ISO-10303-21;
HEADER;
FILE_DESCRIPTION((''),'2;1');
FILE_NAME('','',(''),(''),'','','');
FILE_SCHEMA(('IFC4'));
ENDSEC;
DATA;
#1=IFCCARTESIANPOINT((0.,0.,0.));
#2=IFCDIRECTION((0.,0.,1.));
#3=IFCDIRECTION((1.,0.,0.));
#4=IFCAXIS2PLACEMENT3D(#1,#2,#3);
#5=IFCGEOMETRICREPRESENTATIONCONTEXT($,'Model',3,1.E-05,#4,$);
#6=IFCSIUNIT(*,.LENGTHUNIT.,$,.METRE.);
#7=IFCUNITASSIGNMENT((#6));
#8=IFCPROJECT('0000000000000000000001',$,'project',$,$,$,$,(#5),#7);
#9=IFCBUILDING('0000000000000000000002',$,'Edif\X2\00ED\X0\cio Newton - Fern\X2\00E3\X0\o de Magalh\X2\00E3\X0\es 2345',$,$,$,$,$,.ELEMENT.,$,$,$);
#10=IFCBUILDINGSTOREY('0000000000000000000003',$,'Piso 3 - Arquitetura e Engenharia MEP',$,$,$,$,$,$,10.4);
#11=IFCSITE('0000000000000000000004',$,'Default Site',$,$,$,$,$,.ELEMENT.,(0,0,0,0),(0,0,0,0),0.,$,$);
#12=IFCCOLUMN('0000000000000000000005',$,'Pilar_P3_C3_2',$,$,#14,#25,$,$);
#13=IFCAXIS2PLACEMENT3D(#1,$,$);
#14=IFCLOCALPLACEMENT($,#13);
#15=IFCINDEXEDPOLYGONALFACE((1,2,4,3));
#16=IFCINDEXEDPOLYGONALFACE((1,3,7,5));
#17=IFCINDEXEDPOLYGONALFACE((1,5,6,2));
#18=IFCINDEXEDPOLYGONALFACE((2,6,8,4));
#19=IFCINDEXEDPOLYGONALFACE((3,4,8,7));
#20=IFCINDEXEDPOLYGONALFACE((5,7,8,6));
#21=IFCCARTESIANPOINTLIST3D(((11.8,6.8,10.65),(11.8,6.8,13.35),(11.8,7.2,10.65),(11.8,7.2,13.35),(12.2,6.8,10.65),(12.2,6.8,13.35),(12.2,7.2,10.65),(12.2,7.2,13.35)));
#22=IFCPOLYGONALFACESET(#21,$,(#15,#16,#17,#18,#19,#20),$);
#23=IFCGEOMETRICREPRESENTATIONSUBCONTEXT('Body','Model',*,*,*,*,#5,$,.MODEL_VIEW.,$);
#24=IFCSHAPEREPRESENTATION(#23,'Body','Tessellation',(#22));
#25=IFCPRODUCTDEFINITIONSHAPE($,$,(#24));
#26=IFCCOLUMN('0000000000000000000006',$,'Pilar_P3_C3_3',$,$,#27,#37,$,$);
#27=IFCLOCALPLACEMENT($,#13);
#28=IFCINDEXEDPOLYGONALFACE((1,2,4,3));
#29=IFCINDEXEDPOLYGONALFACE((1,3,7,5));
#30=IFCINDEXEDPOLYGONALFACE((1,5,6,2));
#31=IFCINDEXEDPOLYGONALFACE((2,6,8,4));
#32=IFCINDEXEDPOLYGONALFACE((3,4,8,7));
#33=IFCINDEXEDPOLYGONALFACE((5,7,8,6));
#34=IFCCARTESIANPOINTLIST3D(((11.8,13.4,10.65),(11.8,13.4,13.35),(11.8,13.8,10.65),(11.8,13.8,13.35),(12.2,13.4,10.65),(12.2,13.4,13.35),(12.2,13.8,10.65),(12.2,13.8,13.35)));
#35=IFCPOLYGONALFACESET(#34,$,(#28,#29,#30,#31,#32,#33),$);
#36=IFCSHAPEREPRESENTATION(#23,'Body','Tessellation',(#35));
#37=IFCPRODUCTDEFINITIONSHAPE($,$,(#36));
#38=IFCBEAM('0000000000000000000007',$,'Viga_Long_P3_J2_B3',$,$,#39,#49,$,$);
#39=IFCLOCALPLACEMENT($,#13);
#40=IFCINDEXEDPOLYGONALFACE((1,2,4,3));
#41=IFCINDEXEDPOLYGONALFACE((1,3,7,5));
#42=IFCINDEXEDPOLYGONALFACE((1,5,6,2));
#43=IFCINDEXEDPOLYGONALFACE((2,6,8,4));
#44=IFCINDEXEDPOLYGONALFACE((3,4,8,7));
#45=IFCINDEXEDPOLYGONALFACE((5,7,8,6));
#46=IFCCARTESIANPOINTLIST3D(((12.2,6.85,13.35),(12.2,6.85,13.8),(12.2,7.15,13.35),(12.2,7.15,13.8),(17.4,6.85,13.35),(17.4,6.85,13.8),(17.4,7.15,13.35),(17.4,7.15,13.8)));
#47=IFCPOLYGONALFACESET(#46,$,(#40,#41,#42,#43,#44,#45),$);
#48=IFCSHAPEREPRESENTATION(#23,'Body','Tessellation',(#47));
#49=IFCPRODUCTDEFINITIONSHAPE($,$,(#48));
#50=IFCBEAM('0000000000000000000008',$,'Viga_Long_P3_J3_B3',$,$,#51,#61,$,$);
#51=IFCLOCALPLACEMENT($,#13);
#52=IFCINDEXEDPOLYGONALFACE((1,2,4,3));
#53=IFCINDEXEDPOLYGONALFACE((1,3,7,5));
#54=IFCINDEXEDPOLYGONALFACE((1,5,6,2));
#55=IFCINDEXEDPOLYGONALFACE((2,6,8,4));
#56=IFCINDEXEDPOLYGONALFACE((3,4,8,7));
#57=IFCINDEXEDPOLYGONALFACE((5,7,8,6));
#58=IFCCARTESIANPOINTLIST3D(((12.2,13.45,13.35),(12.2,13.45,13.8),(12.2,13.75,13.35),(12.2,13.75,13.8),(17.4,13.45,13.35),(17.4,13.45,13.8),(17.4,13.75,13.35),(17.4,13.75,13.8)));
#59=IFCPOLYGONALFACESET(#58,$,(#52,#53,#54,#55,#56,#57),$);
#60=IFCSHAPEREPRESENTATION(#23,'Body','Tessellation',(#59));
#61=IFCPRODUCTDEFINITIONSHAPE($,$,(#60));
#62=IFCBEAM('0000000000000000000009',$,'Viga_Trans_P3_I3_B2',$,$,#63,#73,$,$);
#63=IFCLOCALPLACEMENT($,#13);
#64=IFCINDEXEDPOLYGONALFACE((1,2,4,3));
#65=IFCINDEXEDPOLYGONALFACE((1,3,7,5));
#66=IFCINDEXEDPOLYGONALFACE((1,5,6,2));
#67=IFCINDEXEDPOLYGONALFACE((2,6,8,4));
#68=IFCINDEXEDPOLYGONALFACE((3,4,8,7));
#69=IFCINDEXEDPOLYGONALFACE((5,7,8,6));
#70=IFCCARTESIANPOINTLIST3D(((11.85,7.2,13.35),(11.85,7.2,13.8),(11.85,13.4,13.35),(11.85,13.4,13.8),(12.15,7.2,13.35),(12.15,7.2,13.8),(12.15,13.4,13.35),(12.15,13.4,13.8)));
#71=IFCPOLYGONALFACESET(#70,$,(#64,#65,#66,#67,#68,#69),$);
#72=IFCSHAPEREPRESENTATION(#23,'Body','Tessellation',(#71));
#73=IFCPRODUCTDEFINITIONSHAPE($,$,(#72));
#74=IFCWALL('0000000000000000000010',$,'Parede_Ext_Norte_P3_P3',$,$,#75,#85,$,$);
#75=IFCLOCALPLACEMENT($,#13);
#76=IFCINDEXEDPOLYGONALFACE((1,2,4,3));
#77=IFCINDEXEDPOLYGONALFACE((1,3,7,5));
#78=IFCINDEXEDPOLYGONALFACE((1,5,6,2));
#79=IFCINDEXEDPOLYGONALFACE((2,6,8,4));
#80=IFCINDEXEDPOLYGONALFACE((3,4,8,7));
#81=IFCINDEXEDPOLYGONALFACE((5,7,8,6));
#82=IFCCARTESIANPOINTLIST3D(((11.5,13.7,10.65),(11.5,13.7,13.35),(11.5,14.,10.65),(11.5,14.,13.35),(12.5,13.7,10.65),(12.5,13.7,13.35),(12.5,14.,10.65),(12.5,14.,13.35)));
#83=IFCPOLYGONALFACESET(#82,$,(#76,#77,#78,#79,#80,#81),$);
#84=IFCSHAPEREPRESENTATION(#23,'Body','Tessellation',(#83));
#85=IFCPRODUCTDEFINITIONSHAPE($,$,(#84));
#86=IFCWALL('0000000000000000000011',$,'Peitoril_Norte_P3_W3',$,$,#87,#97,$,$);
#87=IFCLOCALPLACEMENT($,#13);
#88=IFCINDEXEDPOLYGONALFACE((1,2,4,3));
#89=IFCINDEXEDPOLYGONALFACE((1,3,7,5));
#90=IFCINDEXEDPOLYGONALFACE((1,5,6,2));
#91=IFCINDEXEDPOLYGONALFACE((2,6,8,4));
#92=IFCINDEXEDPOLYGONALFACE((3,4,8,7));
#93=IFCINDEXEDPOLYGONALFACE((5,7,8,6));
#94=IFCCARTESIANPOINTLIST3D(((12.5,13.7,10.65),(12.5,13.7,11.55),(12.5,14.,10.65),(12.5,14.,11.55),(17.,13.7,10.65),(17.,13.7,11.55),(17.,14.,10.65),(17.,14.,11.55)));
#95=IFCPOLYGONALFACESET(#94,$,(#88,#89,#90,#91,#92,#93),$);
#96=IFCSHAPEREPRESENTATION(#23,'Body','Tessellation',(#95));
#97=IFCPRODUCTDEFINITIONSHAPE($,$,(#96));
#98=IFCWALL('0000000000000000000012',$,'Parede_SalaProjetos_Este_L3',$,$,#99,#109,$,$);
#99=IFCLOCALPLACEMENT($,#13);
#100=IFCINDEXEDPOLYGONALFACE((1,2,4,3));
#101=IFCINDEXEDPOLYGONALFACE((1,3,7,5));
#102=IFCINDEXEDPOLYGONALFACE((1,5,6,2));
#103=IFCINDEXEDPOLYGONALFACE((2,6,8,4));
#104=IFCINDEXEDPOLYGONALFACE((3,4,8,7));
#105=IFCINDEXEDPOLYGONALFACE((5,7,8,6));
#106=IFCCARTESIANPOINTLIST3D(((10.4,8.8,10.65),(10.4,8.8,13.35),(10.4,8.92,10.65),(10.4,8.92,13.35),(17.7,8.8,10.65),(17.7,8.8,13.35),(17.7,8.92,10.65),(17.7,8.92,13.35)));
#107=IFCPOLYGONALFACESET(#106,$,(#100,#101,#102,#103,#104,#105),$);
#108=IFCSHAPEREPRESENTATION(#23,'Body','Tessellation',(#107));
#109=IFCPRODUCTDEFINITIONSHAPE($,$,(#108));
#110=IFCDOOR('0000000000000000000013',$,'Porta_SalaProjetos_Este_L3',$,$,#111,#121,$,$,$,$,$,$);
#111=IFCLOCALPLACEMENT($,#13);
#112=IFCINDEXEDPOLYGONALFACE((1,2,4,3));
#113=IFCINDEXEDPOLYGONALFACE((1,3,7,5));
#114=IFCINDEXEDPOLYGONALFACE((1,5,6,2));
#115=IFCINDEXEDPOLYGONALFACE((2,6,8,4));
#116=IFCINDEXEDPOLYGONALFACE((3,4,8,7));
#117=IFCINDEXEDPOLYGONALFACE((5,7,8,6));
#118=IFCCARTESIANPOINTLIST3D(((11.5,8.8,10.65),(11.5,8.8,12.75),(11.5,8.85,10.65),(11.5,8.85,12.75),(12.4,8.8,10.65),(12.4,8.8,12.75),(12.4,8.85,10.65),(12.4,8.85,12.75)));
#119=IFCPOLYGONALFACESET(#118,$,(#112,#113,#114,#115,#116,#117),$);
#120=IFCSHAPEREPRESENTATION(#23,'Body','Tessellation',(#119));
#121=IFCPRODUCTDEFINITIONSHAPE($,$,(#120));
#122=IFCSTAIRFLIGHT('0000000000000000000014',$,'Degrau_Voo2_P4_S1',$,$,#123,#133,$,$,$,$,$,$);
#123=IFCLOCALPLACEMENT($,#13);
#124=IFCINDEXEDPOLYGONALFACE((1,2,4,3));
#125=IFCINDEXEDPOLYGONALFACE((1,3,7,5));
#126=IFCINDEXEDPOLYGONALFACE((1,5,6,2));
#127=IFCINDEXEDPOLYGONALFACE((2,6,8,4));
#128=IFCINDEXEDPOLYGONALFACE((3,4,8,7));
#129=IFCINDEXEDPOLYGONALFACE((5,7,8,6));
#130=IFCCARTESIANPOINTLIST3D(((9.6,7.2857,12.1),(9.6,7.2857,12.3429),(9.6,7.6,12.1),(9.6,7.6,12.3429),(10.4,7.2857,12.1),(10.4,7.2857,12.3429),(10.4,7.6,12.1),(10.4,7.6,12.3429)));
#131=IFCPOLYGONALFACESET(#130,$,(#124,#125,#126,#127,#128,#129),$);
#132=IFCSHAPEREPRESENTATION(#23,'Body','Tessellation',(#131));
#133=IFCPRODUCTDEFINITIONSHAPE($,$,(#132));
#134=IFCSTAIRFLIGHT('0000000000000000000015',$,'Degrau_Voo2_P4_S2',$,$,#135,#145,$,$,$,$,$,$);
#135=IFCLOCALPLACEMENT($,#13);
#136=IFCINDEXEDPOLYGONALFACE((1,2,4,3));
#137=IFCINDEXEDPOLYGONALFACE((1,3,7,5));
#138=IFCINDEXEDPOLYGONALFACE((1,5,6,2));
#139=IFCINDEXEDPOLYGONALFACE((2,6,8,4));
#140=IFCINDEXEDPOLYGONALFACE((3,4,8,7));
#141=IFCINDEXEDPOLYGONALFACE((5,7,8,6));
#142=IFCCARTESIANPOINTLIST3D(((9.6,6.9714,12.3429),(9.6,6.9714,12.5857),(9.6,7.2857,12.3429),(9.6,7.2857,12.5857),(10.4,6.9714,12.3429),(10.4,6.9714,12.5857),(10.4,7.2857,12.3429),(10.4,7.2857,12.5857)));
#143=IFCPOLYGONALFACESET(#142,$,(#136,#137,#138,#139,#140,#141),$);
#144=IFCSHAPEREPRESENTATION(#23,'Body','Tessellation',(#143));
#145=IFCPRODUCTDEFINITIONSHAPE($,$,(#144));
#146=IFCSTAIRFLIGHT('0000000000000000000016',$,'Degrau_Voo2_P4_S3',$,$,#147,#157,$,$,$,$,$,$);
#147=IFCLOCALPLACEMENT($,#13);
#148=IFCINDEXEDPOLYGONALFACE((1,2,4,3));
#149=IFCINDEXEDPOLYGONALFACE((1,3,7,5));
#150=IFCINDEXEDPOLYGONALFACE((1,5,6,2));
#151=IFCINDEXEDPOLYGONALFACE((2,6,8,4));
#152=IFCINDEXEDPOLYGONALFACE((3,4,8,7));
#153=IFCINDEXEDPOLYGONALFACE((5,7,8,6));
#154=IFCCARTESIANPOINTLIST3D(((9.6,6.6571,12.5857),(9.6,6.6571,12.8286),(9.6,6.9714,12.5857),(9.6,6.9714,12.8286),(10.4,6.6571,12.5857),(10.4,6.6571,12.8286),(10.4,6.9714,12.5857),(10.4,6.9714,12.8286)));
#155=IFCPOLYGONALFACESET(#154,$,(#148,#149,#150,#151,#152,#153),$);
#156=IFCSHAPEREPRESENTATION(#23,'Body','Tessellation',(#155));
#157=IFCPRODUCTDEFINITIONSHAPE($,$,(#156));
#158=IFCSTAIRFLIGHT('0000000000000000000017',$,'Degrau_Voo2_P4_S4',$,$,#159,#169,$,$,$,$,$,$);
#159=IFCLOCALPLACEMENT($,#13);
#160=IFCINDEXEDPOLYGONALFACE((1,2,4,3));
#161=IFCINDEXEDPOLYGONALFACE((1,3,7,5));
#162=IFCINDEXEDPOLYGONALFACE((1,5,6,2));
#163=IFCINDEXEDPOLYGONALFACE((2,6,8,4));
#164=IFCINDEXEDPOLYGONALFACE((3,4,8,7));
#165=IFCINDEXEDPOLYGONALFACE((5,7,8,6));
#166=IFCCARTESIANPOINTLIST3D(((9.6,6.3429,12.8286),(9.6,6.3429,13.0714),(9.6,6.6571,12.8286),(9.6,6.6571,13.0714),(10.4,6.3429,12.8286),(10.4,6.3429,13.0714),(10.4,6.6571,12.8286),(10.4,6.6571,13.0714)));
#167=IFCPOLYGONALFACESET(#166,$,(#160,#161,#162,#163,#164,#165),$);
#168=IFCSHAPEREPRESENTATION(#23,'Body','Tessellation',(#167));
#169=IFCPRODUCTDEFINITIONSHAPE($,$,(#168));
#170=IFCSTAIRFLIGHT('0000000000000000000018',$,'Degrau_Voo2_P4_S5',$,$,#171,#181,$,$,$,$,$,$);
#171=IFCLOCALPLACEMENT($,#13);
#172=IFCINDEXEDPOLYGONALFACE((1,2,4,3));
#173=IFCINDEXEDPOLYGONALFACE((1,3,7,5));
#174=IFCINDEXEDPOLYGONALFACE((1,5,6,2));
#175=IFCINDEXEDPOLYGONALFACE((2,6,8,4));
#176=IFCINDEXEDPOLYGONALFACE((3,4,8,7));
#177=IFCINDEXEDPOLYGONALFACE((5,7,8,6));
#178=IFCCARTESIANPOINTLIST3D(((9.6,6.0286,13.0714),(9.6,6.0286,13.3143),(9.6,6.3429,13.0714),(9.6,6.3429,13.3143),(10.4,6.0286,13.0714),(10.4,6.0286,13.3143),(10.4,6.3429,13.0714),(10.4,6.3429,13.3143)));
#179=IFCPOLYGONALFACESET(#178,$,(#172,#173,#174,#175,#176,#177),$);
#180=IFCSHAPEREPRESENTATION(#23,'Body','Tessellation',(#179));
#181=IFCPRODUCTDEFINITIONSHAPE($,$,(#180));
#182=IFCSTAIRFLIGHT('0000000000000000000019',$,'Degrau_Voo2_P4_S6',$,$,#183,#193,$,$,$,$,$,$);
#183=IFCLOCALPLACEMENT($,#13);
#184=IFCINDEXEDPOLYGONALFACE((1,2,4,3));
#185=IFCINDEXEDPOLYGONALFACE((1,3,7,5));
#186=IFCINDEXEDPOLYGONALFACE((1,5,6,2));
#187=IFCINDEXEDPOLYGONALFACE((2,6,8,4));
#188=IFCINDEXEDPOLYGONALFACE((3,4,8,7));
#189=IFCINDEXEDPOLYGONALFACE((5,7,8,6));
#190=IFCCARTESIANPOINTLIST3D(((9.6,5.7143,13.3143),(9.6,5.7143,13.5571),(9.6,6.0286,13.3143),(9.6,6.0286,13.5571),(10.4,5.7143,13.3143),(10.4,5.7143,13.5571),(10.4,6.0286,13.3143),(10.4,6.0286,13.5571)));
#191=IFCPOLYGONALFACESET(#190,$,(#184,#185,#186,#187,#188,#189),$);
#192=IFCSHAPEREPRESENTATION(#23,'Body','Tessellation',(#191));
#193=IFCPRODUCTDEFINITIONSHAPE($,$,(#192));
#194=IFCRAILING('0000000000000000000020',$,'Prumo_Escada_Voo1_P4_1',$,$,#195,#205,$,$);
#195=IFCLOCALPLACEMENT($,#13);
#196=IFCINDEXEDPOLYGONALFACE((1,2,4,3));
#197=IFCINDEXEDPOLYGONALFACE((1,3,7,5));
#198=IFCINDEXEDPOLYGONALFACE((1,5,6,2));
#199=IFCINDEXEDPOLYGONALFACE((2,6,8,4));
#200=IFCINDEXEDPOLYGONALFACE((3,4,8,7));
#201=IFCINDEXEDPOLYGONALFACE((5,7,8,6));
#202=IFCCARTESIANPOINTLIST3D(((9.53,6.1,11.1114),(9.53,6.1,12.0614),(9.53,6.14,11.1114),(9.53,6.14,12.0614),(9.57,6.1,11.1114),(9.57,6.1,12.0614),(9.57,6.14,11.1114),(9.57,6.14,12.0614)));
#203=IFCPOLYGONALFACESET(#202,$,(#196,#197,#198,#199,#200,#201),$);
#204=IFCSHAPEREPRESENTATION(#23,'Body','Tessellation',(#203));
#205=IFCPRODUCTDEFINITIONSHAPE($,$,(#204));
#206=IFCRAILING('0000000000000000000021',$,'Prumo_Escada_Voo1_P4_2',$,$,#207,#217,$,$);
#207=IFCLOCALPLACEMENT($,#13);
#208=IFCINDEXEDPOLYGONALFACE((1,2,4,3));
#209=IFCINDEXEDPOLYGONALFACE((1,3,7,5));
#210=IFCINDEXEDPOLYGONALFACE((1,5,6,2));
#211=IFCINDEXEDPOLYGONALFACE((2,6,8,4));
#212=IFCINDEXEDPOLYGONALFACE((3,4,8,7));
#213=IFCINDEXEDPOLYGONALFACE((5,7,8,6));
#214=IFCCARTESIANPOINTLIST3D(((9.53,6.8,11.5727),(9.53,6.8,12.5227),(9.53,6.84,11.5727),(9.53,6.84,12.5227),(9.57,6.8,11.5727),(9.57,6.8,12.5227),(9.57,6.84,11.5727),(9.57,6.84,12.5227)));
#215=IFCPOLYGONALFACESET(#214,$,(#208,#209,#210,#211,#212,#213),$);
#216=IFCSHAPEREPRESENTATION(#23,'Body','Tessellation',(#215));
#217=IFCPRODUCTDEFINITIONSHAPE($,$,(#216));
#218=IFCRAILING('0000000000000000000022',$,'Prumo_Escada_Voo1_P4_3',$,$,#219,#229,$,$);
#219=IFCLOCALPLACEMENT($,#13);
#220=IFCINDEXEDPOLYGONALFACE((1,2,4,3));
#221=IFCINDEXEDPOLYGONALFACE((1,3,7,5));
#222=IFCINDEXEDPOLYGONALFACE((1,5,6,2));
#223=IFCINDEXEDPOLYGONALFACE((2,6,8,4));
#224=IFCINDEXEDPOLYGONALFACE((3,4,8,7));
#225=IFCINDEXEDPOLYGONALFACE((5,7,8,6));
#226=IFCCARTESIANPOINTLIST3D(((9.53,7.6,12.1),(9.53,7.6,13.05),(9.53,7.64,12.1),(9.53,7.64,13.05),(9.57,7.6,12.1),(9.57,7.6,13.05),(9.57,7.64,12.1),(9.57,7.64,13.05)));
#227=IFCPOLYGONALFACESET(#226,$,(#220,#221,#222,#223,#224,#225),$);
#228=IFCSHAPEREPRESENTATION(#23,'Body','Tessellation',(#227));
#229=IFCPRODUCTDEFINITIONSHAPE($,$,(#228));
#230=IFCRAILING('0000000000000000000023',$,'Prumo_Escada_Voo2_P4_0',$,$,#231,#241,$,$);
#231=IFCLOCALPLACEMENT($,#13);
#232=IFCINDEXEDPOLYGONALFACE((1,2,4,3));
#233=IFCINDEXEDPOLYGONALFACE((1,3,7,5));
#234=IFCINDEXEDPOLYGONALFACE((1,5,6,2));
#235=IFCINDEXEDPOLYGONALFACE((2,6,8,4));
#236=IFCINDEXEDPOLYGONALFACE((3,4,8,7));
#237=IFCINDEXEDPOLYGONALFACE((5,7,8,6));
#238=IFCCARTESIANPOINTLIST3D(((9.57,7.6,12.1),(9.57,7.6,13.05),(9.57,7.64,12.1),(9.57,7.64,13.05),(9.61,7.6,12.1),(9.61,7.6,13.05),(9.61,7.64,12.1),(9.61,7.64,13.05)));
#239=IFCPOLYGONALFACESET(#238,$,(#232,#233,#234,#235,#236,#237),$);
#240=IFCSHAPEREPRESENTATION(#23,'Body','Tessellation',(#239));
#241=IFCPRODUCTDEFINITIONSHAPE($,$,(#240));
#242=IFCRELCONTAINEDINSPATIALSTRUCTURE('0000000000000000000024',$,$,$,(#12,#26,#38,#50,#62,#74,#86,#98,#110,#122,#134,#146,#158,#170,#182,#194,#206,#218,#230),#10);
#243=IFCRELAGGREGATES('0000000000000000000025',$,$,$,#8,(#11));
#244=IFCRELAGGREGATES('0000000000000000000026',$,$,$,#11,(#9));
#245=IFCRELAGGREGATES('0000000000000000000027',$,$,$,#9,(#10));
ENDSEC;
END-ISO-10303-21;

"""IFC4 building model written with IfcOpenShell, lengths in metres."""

from ifc_helpers import new_model, si_unit, frame, frame_2d, origin_with_axes, place, context, subcontext, project, spatial, rectangle, extrude, element, save


model = new_model("IFC4")

# Units and contexts
model_context = context("Model", 3, precision=1e-05, world=origin_with_axes())
body_context = subcontext(model_context, "Body", "Model", "MODEL_VIEW")
ifc_project = project(units=[si_unit("LENGTHUNIT", "METRE")], contexts=[model_context])

# Site, building, storey
site = spatial("IfcSite", under=ifc_project, Name="Default Site", CompositionType="ELEMENT", RefLatitude=(0, 0, 0, 0), RefLongitude=(0, 0, 0, 0), RefElevation=0.0)
building = spatial("IfcBuilding", under=site, Name="Edifício Newton - Fernão de Magalhães 2345", CompositionType="ELEMENT")
storey = spatial("IfcBuildingStorey", under=building, Name="Piso 3 - Arquitetura e Engenharia MEP", Elevation=10.4)

# Columns
for number, where, z_axis, x_axis, name in (
    (1, (11.8, 6.8, 10.65), (0.0, 0.0, 1.0), (1.0, 0.0, 0.0), "Pilar_P3_C3_2"),
    (2, (11.8, 13.4, 10.65), (0.0, 0.0, 1.0), (1.0, 0.0, 0.0), "Pilar_P3_C3_3"),
):
    element("IfcColumn", number, at=place(None, frame(where, z_axis=z_axis, x_axis=x_axis)), inside=storey, Name=name, context=body_context, shape_type="SweptSolid", body=[
        extrude(rectangle(XDim=0.4, YDim=0.4, at=frame_2d((0.2, 0.2))), origin_with_axes(), (0.0, 0.0, 1.0), 2.7),
    ])

# Beams
for number, where, z_axis, x_axis, name in (
    (3, (12.2, 6.85, 13.35), (0.0, 0.0, 1.0), (1.0, 0.0, 0.0), "Viga_Long_P3_J2_B3"),
    (4, (12.2, 13.45, 13.35), (0.0, 0.0, 1.0), (1.0, 0.0, 0.0), "Viga_Long_P3_J3_B3"),
):
    element("IfcBeam", number, at=place(None, frame(where, z_axis=z_axis, x_axis=x_axis)), inside=storey, Name=name, context=body_context, shape_type="SweptSolid", body=[
        extrude(rectangle(XDim=5.2, YDim=0.3, at=frame_2d((2.6, 0.15))), origin_with_axes(), (0.0, 0.0, 1.0), 0.45),
    ])
beam_placement = place(None, frame((11.85, 7.2, 13.35), z_axis=(0.0, 0.0, 1.0), x_axis=(1.0, 0.0, 0.0)))
element("IfcBeam", 5, at=beam_placement, inside=storey, Name="Viga_Trans_P3_I3_B2", context=body_context, shape_type="SweptSolid", body=[
    extrude(rectangle(XDim=0.3, YDim=6.2, at=frame_2d((0.15, 3.1))), origin_with_axes(), (0.0, 0.0, 1.0), 0.45),
])

# Walls
wall_1_placement = place(None, frame((11.5, 13.7, 10.65), z_axis=(0.0, 0.0, 1.0), x_axis=(1.0, 0.0, 0.0)))
element("IfcWall", 6, at=wall_1_placement, inside=storey, Name="Parede_Ext_Norte_P3_P3", context=body_context, shape_type="SweptSolid", body=[
    extrude(rectangle(XDim=1.0, YDim=0.3, at=frame_2d((0.5, 0.15))), origin_with_axes(), (0.0, 0.0, 1.0), 2.7),
])
wall_2_placement = place(None, frame((12.5, 13.7, 10.65), z_axis=(0.0, 0.0, 1.0), x_axis=(1.0, 0.0, 0.0)))
element("IfcWall", 7, at=wall_2_placement, inside=storey, Name="Peitoril_Norte_P3_W3", context=body_context, shape_type="SweptSolid", body=[
    extrude(rectangle(XDim=4.5, YDim=0.3, at=frame_2d((2.25, 0.15))), origin_with_axes(), (0.0, 0.0, 1.0), 0.9),
])
wall_3_placement = place(None, frame((10.4, 8.8, 10.65), z_axis=(0.0, 0.0, 1.0), x_axis=(1.0, 0.0, 0.0)))
element("IfcWall", 8, at=wall_3_placement, inside=storey, Name="Parede_SalaProjetos_Este_L3", context=body_context, shape_type="SweptSolid", body=[
    extrude(rectangle(XDim=7.3, YDim=0.12, at=frame_2d((3.65, 0.06))), origin_with_axes(), (0.0, 0.0, 1.0), 2.7),
])

# Door
door_placement = place(None, frame((11.5, 8.8, 10.65), z_axis=(0.0, 0.0, 1.0), x_axis=(1.0, 0.0, 0.0)))
element("IfcDoor", 9, at=door_placement, inside=storey, Name="Porta_SalaProjetos_Este_L3", context=body_context, shape_type="SweptSolid", body=[
    extrude(rectangle(XDim=0.9, YDim=0.05, at=frame_2d((0.45, 0.025))), origin_with_axes(), (0.0, 0.0, 1.0), 2.1),
])

# Stair flights
for number, where, z_axis, x_axis, name in (
    (10, (9.6, 7.2857, 12.1), (0.0, 0.0, 1.0), (1.0, 0.0, 0.0), "Degrau_Voo2_P4_S1"),
    (11, (9.6, 6.9714, 12.3429), (0.0, 0.0, 1.0), (1.0, 0.0, 0.0), "Degrau_Voo2_P4_S2"),
    (12, (9.6, 6.6571, 12.5857), (0.0, 0.0, 1.0), (1.0, 0.0, 0.0), "Degrau_Voo2_P4_S3"),
    (13, (9.6, 6.3429, 12.8286), (0.0, 0.0, 1.0), (1.0, 0.0, 0.0), "Degrau_Voo2_P4_S4"),
    (14, (9.6, 6.0286, 13.0714), (0.0, 0.0, 1.0), (1.0, 0.0, 0.0), "Degrau_Voo2_P4_S5"),
    (15, (9.6, 5.7143, 13.3143), (0.0, 0.0, 1.0), (1.0, 0.0, 0.0), "Degrau_Voo2_P4_S6"),
):
    element("IfcStairFlight", number, at=place(None, frame(where, z_axis=z_axis, x_axis=x_axis)), inside=storey, Name=name, context=body_context, shape_type="SweptSolid", body=[
        extrude(rectangle(XDim=0.8, YDim=0.3143, at=frame_2d((0.4, 0.1571))), origin_with_axes(), (0.0, 0.0, 1.0), 0.2429),
    ])

# Railings
for number, where, z_axis, x_axis, name in (
    (16, (9.53, 6.1, 11.1114), (0.0, 0.0, 1.0), (1.0, 0.0, 0.0), "Prumo_Escada_Voo1_P4_1"),
    (17, (9.53, 6.8, 11.5727), (0.0, 0.0, 1.0), (1.0, 0.0, 0.0), "Prumo_Escada_Voo1_P4_2"),
    (18, (9.53, 7.6, 12.1), (0.0, 0.0, 1.0), (1.0, 0.0, 0.0), "Prumo_Escada_Voo1_P4_3"),
    (19, (9.57, 7.6, 12.1), (0.0, 0.0, 1.0), (1.0, 0.0, 0.0), "Prumo_Escada_Voo2_P4_0"),
):
    element("IfcRailing", number, at=place(None, frame(where, z_axis=z_axis, x_axis=x_axis)), inside=storey, Name=name, context=body_context, shape_type="SweptSolid", body=[
        extrude(rectangle(XDim=0.04, YDim=0.04, at=frame_2d((0.02, 0.02))), origin_with_axes(), (0.0, 0.0, 1.0), 0.95),
    ])

save(model, "model.ifc")
